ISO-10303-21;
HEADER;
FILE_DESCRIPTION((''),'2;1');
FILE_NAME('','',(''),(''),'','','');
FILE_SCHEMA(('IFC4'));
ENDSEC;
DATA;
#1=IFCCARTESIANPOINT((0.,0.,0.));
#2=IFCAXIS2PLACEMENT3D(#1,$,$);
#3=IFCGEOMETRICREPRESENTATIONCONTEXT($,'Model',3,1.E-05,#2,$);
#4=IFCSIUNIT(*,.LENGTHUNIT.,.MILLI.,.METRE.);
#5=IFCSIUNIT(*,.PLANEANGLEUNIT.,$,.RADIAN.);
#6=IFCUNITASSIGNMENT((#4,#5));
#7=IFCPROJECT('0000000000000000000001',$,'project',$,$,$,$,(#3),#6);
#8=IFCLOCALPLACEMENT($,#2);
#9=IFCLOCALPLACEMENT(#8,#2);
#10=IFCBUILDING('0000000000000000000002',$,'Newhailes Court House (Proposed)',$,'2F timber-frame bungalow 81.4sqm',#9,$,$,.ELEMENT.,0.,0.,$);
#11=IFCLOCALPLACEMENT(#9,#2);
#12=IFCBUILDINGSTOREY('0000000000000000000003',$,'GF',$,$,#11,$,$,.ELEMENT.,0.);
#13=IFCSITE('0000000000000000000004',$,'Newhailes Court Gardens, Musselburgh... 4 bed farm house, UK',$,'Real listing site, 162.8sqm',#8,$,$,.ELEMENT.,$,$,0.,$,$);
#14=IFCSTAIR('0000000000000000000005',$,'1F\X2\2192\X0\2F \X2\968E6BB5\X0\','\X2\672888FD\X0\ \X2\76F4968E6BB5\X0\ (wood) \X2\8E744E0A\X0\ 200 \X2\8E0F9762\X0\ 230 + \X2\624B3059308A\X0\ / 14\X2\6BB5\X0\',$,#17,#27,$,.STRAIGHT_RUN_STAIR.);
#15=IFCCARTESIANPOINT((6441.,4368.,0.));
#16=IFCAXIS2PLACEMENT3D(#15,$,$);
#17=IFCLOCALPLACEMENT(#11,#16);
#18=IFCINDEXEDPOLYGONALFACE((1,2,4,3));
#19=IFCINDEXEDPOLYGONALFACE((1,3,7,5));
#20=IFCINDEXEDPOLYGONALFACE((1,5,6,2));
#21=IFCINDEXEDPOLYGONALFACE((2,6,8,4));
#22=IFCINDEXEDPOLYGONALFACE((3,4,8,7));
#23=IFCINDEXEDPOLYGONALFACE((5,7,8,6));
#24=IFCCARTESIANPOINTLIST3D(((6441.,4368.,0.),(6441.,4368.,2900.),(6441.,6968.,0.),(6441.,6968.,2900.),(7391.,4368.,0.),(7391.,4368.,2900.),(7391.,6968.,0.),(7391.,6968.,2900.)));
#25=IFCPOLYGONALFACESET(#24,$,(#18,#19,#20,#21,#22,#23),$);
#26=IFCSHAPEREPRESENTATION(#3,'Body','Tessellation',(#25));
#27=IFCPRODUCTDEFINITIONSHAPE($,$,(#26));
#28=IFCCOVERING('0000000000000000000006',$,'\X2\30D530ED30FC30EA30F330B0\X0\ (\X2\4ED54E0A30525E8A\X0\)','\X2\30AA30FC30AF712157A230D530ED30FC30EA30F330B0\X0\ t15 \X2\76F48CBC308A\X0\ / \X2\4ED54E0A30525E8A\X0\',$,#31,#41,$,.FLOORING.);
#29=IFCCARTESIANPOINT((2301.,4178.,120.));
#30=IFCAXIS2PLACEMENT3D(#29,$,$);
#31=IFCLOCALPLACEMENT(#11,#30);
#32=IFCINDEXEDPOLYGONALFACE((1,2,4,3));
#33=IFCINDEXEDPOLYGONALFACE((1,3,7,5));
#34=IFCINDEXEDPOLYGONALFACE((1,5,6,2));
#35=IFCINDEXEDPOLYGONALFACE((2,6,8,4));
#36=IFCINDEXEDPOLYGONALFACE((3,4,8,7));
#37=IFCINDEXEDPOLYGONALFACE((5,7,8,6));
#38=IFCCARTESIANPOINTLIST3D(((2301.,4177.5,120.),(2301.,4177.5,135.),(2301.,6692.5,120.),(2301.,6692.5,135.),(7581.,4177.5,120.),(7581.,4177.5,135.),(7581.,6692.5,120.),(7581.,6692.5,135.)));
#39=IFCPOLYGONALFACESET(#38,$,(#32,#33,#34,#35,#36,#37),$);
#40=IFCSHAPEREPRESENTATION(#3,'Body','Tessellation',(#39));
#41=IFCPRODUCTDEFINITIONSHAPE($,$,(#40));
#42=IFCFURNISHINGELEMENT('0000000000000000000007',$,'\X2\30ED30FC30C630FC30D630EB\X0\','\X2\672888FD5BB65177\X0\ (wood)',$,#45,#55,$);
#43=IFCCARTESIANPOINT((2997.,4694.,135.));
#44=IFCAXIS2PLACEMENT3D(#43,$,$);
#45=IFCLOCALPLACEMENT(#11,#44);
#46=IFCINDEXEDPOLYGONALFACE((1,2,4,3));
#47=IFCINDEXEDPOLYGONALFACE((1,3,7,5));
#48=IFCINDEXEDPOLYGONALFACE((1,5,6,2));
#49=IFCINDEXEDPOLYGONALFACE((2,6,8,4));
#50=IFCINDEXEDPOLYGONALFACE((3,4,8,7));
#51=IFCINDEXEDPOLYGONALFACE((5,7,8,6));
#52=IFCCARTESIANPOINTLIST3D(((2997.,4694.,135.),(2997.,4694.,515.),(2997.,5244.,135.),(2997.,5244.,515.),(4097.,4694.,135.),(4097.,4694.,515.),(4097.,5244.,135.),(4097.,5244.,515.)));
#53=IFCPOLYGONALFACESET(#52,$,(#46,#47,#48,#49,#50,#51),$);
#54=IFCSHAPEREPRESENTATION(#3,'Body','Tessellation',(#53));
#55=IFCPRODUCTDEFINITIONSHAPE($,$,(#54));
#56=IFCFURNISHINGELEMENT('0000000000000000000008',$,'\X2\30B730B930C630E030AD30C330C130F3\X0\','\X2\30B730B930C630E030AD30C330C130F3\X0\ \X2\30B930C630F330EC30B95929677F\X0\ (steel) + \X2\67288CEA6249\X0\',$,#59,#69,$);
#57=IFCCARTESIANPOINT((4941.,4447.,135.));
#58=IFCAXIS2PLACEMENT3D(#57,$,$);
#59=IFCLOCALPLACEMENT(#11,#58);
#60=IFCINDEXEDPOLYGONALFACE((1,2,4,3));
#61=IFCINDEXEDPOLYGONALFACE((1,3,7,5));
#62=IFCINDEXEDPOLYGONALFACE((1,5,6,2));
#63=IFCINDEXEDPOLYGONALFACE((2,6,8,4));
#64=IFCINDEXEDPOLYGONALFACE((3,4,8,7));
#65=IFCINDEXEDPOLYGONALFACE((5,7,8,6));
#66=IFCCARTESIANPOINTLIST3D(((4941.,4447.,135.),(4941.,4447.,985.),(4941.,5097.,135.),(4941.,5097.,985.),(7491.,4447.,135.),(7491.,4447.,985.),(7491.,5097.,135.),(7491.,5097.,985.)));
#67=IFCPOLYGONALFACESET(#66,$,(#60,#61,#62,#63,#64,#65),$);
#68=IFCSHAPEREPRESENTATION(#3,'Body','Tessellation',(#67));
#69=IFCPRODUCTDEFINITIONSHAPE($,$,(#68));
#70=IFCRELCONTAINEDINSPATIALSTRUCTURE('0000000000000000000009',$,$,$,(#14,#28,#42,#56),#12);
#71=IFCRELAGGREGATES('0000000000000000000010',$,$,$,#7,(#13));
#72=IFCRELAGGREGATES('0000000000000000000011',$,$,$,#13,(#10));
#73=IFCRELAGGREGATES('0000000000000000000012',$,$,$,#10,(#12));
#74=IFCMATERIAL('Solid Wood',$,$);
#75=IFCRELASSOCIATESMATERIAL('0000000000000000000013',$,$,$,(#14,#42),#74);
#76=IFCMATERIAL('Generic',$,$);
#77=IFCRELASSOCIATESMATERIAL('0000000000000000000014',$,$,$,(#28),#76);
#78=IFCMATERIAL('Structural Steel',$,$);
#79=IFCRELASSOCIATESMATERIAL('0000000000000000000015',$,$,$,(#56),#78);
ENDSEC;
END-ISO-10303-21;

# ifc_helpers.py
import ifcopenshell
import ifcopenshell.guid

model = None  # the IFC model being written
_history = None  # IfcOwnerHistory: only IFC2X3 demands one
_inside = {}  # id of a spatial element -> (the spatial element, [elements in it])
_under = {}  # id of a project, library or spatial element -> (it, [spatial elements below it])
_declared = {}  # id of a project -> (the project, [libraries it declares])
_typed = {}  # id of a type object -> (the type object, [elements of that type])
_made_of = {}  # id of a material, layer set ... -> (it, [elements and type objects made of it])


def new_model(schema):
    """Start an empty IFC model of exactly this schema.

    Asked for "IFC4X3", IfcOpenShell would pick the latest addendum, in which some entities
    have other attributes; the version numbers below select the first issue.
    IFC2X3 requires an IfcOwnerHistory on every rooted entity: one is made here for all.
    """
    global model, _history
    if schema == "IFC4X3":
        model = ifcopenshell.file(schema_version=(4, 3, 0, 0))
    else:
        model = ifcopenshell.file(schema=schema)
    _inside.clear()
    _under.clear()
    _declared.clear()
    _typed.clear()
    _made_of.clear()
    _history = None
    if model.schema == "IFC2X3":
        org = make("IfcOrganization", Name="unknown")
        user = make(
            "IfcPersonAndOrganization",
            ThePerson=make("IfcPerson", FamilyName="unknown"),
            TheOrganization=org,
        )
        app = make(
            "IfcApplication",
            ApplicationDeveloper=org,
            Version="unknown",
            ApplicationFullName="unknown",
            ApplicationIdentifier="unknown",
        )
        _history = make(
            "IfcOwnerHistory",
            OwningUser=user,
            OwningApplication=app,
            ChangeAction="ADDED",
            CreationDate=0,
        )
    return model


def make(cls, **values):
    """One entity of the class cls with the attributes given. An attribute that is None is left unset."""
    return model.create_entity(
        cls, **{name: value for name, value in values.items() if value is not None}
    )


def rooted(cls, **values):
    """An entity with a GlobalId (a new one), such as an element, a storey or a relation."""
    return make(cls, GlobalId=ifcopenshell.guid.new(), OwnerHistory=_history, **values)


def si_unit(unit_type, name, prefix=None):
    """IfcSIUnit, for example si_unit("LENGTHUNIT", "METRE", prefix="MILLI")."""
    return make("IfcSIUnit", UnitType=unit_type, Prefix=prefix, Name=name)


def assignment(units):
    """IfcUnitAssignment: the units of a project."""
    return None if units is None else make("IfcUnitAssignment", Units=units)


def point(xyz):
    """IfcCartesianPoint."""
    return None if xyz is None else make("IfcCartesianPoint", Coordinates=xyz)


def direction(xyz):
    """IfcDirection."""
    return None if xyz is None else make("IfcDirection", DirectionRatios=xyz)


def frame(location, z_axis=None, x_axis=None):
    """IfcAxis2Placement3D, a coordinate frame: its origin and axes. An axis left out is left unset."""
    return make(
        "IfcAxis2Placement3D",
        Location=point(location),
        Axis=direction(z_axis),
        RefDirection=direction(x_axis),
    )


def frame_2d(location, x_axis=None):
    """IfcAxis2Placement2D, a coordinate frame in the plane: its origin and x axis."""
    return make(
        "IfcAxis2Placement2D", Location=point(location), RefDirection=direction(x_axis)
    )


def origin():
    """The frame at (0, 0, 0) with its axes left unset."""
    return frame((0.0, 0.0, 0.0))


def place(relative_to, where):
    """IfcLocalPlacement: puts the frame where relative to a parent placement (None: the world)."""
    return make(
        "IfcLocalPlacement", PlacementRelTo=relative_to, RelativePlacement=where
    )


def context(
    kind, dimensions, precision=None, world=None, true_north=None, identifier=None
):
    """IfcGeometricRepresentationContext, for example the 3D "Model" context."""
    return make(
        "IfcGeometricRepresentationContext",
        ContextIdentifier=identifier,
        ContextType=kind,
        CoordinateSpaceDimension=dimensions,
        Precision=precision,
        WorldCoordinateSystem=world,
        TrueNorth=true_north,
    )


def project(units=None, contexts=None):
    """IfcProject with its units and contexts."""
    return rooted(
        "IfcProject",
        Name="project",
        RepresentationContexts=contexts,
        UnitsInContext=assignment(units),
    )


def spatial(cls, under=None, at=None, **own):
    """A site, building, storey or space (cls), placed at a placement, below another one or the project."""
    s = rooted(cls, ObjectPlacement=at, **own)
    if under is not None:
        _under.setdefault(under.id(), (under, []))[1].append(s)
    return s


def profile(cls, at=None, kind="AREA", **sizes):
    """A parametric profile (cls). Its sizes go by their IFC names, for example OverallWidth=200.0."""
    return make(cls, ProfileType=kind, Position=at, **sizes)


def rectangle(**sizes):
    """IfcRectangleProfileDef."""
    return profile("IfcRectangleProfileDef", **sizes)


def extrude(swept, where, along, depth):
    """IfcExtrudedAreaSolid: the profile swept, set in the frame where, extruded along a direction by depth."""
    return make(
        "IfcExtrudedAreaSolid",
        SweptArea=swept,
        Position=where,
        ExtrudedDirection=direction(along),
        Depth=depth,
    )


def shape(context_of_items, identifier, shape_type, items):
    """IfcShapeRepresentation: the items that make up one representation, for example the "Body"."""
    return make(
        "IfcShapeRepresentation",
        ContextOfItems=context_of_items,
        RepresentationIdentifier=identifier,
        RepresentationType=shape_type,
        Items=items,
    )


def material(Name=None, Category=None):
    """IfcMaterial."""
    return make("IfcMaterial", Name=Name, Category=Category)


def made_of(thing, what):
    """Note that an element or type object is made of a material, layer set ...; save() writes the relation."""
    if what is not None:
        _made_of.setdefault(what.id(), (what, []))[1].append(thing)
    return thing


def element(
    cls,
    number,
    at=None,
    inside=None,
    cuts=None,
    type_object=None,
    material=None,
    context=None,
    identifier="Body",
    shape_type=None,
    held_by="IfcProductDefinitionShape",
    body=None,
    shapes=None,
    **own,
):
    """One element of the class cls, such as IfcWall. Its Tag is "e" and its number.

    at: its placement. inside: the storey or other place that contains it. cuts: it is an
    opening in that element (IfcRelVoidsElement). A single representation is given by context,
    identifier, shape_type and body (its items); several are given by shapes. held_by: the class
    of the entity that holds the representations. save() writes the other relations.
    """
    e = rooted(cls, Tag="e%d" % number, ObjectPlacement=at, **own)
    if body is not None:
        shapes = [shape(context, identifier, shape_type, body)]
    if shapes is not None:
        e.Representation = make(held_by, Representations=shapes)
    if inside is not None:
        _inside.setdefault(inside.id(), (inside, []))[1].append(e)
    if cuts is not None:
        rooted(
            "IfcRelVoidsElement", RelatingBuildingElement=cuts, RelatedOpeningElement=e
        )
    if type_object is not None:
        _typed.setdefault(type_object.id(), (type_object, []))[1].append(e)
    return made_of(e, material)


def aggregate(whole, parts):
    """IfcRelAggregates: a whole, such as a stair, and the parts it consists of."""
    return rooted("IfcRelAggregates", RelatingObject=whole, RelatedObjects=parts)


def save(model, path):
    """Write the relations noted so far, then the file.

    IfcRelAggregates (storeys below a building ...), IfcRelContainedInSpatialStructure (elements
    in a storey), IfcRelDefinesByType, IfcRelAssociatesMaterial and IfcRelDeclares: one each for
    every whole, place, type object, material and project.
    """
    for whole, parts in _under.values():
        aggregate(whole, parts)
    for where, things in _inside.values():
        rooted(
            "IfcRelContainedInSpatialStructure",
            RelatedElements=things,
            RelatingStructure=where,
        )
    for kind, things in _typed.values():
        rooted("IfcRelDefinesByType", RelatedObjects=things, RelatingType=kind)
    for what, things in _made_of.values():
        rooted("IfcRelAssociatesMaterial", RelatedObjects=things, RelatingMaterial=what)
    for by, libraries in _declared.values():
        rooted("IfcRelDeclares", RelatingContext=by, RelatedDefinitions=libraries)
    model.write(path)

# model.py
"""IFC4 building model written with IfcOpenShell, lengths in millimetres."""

from ifc_helpers import new_model, si_unit, frame, frame_2d, origin, place, context, project, spatial, rectangle, extrude, material, element, save


model = new_model("IFC4")

# Units and contexts
model_context = context("Model", 3, precision=1e-05, world=origin())
ifc_project = project(units=[si_unit("LENGTHUNIT", "METRE", prefix="MILLI"), si_unit("PLANEANGLEUNIT", "RADIAN")], contexts=[model_context])

# Site, building, storey
site_placement = place(None, origin())
site = spatial("IfcSite", under=ifc_project, at=site_placement, Name="Newhailes Court Gardens, Musselburgh... 4 bed farm house, UK", ObjectType="Real listing site, 162.8sqm", CompositionType="ELEMENT", RefElevation=0.0)
building_placement = place(site_placement, origin())
building = spatial("IfcBuilding", under=site, at=building_placement, Name="Newhailes Court House (Proposed)", ObjectType="2F timber-frame bungalow 81.4sqm", CompositionType="ELEMENT", ElevationOfRefHeight=0.0, ElevationOfTerrain=0.0)
storey_placement = place(building_placement, origin())
storey = spatial("IfcBuildingStorey", under=building, at=storey_placement, Name="GF", CompositionType="ELEMENT", Elevation=0.0)

# Shared definitions
ifc_material_1 = material(Name="Solid Wood")

# Stair
stair_placement = place(storey_placement, frame((6441.0, 4368.0, 0.0)))
element("IfcStair", 1, at=stair_placement, inside=storey, material=ifc_material_1, Name="1F→2F 階段", Description="木製 直階段 (wood) 蹴上 200 踏面 230 + 手すり / 14段", PredefinedType="STRAIGHT_RUN_STAIR", context=model_context, shape_type="SweptSolid", body=[
    extrude(rectangle(XDim=950.0, YDim=2600.0, at=frame_2d((475.0, 1300.0))), frame((6441.0, 4368.0, 0.0)), (0.0, 0.0, 1.0), 2900.0),
])

# Covering
ifc_material_2 = material(Name="Generic")
covering_placement = place(storey_placement, frame((2301.0, 4178.0, 120.0)))
element("IfcCovering", 2, at=covering_placement, inside=storey, material=ifc_material_2, Name="フローリング (仕上げ床)", Description="オーク無垢フローリング t15 直貼り / 仕上げ床", PredefinedType="FLOORING", context=model_context, shape_type="SweptSolid", body=[
    extrude(rectangle(XDim=5280.0, YDim=2515.0, at=frame_2d((2640.0, 1257.0))), frame((2301.0, 4178.0, 120.0)), (0.0, 0.0, 1.0), 15.0),
])

# Furnishing elements
furnishing_1_placement = place(storey_placement, frame((2997.0, 4694.0, 135.0)))
element("IfcFurnishingElement", 3, at=furnishing_1_placement, inside=storey, material=ifc_material_1, Name="ローテーブル", Description="木製家具 (wood)", context=model_context, shape_type="SweptSolid", body=[
    extrude(rectangle(XDim=1100.0, YDim=550.0, at=frame_2d((550.0, 275.0))), frame((2997.0, 4694.0, 135.0)), (0.0, 0.0, 1.0), 380.0),
])
ifc_material_3 = material(Name="Structural Steel")
furnishing_2_placement = place(storey_placement, frame((4941.0, 4447.0, 135.0)))
element("IfcFurnishingElement", 4, at=furnishing_2_placement, inside=storey, material=ifc_material_3, Name="システムキッチン", Description="システムキッチン ステンレス天板 (steel) + 木質扉", context=model_context, shape_type="SweptSolid", body=[
    extrude(rectangle(XDim=2550.0, YDim=650.0, at=frame_2d((1275.0, 325.0))), frame((4941.0, 4447.0, 135.0)), (0.0, 0.0, 1.0), 850.0),
])

save(model, "model.ifc")
